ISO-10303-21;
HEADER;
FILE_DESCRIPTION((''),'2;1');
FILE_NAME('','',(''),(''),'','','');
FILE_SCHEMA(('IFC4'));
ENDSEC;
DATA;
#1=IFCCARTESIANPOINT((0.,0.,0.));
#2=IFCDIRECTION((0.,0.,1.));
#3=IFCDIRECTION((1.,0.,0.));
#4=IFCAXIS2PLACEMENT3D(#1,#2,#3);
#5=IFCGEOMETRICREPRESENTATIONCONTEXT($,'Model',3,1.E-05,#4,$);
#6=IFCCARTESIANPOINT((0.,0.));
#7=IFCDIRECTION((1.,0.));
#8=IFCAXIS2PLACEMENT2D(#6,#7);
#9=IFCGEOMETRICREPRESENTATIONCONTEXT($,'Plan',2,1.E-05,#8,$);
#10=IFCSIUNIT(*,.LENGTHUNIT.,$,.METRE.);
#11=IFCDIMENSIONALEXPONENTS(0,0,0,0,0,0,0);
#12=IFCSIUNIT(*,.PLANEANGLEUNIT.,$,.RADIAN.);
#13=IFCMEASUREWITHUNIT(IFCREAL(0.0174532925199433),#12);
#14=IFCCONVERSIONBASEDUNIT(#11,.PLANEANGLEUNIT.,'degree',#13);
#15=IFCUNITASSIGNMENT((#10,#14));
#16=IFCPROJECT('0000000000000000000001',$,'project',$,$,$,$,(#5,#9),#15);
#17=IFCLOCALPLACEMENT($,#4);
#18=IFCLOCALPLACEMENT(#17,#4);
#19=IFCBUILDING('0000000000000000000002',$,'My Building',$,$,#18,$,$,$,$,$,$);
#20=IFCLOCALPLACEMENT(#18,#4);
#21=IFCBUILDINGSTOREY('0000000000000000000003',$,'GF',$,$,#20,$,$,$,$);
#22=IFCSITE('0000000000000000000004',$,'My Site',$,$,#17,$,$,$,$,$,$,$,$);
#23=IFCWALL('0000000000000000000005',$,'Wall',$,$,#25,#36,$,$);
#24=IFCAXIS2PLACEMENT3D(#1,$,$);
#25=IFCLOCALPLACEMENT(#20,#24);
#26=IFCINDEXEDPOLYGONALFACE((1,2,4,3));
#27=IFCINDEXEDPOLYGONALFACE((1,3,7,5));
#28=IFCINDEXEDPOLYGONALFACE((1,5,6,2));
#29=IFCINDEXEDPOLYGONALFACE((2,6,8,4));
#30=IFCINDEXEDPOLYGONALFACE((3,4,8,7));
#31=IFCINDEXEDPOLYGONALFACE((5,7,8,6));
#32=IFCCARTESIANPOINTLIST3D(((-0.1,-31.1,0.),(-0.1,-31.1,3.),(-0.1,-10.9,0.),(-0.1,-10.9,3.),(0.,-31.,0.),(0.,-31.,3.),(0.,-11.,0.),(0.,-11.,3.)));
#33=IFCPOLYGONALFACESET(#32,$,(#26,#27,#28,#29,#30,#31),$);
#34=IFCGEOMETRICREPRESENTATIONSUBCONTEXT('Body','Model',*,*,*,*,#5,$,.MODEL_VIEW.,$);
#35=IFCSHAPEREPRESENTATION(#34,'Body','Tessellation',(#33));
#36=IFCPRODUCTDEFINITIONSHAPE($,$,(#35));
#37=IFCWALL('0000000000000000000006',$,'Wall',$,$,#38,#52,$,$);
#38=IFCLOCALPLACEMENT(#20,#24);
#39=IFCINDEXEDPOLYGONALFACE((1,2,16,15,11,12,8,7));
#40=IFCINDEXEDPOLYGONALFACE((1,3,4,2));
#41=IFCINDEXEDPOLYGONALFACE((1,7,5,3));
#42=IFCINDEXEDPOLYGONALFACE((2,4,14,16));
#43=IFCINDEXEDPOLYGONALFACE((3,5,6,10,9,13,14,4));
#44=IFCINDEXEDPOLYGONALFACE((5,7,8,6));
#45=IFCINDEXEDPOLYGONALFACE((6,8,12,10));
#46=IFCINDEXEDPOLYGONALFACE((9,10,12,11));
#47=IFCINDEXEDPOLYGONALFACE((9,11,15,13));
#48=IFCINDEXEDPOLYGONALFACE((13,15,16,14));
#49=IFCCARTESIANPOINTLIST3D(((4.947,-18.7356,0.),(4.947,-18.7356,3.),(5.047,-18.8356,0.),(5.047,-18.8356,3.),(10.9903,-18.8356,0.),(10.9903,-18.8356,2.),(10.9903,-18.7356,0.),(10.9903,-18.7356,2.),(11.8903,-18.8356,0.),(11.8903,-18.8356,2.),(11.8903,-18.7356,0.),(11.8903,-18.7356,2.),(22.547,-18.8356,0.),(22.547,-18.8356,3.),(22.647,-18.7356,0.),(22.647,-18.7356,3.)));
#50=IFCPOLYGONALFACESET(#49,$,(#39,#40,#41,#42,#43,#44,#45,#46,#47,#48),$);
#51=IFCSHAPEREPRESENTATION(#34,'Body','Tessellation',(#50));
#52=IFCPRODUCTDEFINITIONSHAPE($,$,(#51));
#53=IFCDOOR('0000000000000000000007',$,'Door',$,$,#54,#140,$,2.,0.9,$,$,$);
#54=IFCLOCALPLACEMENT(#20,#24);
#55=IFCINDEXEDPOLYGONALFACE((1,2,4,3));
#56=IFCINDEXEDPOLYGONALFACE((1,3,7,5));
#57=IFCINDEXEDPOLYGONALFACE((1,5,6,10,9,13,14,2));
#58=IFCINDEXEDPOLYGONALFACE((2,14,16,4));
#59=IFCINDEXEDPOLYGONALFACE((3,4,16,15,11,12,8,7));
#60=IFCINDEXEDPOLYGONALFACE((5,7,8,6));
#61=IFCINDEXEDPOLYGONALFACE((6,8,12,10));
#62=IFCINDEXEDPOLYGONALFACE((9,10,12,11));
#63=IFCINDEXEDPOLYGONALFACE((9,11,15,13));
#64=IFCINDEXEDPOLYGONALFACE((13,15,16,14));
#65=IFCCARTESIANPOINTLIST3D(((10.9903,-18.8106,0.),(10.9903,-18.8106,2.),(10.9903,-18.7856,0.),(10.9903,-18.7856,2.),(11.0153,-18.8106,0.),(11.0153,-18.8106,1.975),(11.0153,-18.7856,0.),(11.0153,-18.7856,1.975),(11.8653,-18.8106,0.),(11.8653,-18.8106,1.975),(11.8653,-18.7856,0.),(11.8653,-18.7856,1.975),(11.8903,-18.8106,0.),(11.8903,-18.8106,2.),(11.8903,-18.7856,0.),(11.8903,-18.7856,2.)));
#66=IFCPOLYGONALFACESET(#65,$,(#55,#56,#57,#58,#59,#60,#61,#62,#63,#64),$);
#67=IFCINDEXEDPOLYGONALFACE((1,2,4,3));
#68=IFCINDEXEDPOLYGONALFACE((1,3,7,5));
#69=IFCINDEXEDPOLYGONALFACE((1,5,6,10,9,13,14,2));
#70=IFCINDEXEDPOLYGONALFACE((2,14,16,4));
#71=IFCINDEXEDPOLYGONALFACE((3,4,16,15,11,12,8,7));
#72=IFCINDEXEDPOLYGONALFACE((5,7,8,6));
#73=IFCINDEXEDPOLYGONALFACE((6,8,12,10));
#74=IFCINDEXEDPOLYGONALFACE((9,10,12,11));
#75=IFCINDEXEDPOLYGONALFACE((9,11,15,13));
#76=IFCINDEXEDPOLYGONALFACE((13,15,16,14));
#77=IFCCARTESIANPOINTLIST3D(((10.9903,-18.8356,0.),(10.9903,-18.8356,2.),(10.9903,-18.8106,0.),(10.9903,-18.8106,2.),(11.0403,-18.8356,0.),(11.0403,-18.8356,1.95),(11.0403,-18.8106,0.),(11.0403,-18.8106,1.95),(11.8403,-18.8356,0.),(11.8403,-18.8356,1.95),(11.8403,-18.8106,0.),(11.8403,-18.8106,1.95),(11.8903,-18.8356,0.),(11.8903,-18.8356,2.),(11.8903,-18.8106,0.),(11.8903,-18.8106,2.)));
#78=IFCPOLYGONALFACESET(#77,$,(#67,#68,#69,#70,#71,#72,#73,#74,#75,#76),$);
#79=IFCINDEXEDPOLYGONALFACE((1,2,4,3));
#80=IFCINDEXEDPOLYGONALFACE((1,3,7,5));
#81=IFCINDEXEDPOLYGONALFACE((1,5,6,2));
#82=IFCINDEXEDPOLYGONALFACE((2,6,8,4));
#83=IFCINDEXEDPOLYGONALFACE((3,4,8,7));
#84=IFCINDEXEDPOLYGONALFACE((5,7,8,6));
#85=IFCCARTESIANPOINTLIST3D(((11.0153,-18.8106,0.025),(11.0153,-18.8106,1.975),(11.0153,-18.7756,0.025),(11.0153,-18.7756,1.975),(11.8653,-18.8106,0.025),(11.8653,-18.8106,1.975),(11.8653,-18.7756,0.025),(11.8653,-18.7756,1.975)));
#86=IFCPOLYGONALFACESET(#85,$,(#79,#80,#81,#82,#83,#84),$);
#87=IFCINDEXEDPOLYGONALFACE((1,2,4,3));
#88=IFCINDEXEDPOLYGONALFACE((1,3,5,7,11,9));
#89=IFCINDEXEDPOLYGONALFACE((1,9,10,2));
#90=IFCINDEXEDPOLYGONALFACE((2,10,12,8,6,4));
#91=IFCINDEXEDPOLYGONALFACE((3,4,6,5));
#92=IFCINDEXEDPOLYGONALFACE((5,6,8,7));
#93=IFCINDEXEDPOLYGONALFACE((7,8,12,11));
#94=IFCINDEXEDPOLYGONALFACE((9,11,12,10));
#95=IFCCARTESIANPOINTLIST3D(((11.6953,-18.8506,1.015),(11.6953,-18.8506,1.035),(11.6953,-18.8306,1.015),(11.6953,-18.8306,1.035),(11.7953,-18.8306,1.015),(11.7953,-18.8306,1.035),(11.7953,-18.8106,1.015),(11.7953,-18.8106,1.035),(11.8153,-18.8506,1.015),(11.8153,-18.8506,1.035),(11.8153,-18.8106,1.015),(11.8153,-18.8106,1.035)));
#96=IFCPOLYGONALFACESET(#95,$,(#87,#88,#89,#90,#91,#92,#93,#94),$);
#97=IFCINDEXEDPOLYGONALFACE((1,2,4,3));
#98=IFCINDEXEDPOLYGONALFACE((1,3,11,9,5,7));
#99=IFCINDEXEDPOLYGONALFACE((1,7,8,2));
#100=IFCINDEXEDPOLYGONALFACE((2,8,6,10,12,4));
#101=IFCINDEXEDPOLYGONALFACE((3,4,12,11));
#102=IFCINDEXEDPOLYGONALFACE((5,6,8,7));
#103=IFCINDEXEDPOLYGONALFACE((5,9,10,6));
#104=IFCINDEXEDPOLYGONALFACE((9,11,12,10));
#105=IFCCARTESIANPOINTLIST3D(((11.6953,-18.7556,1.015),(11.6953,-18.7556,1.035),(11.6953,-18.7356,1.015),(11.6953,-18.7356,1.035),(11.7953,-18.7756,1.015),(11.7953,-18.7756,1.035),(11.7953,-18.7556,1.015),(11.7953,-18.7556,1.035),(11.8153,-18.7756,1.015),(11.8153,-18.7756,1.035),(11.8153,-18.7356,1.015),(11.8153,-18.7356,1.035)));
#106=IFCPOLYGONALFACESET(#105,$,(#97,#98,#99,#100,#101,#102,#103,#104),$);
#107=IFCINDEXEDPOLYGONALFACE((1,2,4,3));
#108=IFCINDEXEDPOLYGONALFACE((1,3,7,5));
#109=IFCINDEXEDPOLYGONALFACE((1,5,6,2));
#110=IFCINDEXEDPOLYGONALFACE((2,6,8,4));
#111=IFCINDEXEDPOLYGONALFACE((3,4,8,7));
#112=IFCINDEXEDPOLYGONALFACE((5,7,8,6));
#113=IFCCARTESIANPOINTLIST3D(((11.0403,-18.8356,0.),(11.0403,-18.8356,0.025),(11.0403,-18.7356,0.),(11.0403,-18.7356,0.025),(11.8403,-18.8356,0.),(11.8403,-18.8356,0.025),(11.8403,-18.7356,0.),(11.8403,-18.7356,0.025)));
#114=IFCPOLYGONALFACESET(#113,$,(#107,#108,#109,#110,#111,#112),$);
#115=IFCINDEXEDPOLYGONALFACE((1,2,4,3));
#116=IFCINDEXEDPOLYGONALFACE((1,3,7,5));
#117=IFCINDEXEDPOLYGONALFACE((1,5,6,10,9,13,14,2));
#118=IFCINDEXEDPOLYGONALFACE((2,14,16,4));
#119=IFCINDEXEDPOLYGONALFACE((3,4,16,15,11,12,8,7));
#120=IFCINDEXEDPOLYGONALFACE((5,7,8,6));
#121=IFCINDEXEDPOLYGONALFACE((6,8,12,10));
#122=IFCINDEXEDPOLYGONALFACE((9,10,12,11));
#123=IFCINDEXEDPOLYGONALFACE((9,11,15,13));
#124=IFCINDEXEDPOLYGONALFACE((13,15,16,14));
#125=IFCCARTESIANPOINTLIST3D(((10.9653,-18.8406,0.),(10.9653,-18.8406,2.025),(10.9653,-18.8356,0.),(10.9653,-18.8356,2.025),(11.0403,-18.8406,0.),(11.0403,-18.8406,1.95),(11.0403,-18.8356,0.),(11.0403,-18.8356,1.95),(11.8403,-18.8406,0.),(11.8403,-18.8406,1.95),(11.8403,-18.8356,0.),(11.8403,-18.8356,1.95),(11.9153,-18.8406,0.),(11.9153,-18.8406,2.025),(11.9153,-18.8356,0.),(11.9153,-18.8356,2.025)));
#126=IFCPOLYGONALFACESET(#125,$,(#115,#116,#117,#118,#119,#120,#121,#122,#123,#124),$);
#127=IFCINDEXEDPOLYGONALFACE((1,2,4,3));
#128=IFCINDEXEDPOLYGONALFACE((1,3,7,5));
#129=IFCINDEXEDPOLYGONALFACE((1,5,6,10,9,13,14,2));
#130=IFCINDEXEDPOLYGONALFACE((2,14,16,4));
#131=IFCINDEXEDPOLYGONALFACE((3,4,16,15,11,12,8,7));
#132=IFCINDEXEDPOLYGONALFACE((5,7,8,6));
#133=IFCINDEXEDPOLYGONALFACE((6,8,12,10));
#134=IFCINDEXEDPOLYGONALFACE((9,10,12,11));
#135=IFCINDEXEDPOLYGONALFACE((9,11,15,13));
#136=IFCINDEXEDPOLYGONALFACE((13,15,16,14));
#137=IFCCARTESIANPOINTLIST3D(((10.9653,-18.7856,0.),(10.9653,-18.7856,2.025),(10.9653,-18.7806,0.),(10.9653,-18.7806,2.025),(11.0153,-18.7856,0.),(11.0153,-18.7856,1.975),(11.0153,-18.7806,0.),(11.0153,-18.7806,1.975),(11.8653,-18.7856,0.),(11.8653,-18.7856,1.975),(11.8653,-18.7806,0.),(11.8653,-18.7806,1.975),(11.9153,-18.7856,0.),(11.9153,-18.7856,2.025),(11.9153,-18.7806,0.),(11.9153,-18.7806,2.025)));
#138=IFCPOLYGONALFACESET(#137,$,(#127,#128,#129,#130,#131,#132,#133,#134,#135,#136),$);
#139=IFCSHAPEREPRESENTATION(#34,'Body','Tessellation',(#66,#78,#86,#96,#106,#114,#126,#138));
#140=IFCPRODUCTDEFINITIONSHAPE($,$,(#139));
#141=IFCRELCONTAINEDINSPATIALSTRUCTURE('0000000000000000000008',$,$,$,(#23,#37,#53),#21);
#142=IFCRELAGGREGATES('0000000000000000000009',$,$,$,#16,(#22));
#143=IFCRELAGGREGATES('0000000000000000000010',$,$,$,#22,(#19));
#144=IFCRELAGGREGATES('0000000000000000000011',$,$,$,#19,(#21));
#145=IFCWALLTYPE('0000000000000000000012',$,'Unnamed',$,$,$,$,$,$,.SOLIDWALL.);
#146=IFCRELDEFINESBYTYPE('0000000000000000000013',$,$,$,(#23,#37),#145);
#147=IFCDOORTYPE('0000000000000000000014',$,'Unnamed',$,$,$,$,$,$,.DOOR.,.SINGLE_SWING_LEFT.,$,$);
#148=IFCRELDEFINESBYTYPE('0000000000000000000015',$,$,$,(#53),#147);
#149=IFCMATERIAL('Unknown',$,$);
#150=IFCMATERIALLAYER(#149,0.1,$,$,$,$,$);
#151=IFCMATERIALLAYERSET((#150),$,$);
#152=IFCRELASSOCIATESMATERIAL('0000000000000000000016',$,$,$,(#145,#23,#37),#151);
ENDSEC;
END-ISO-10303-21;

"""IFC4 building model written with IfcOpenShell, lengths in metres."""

from ifc_helpers import new_model, entity, si_unit, converted_unit, frame, origin_with_axes, origin_2d_with_axis, place, context, subcontext, project, spatial, line, indexed_curve, outline, extrude, shape, source, transform, mapped, material, layer, layer_set, layer_usage, type_object, type_shapes, element, fill, save


model = new_model("IFC4")

# Units and contexts
model_context = context("Model", 3, precision=1e-05, world=origin_with_axes())
plan_context = context("Plan", 2, precision=1e-05, world=origin_2d_with_axis())
body_context_1 = subcontext(model_context, "Body", "Model", "MODEL_VIEW")
body_context_2 = subcontext(plan_context, "Body", "Plan", "PLAN_VIEW")
ifc_project = project(units=[si_unit("LENGTHUNIT", "METRE"), converted_unit("PLANEANGLEUNIT", "degree", entity("IfcReal", 0.0174532925199433), si_unit("PLANEANGLEUNIT", "RADIAN"), dimensions=[0, 0, 0, 0, 0, 0, 0])], contexts=[model_context, plan_context])

# Site, building, storey
site_placement = place(None, origin_with_axes())
site = spatial("IfcSite", under=ifc_project, at=site_placement, Name="My Site")
building_placement = place(site_placement, origin_with_axes())
building = spatial("IfcBuilding", under=site, at=building_placement, Name="My Building")
storey_placement = place(building_placement, origin_with_axes())
storey = spatial("IfcBuildingStorey", under=building, at=storey_placement, Name="GF")

# Wall
ifc_material = material(Name="Unknown")
ifc_layer = layer(ifc_material, 0.1)
ifc_layer_set = layer_set([ifc_layer])
ifc_layer_usage_1 = layer_usage(ifc_layer_set, "AXIS2", "POSITIVE", 0.0)
wall_type = type_object("IfcWallType", Name="Unnamed", PredefinedType="SOLIDWALL", material=ifc_layer_set)
wall_1_placement = place(storey_placement, frame((0.0, -31.0, 0.0), z_axis=(0.0, 0.0, 1.0), x_axis=(0.0, 1.0, 0.0)))
element("IfcWall", 1, at=wall_1_placement, inside=storey, type_object=wall_type, material=ifc_layer_usage_1, Name="Wall", context=body_context_1, shape_type="SweptSolid", body=[
    extrude(outline(indexed_curve([(0.0, 0.0), (-0.1, 0.1), (20.1, 0.1), (20.0, 0.0)], segments=[line(1, 2, 3, 4, 1)])), origin_with_axes(), (0.0, 0.0, 1.0), 3.0),
])

# Shared definitions
shared_shape_1 = source(origin_with_axes(), body_context_1, "Body", "SweptSolid", [
    extrude(outline(indexed_curve([(0.0, 0.0), (0.9, 0.0), (0.9, 2.0), (0.0, 2.0)], segments=[line(1, 2, 3, 4, 1)])), frame((0.0, -0.6, 0.0), z_axis=(0.0, -1.0, 0.0), x_axis=(1.0, 0.0, 0.0)), (0.0, 0.0, -1.0), 1.2),
])
door_type = type_object("IfcDoorType", Name="Unnamed", OperationType="SINGLE_SWING_LEFT", PredefinedType="DOOR")
shared_shape_2 = source(origin_with_axes(), body_context_1, "Body", "SweptSolid", [
    extrude(outline(indexed_curve([(0.0, 0.0), (0.0, 2.0), (0.9, 2.0), (0.9, 0.0), (0.875, 0.0), (0.875, 1.975), (0.025, 1.975), (0.025, 0.0)], segments=[line(1, 2, 3, 4, 5, 6, 7, 8, 1)])), frame((0.0, 0.025, 0.0), z_axis=(0.0, -1.0, 0.0), x_axis=(1.0, 0.0, 0.0)), (0.0, 0.0, -1.0), 0.025),
    extrude(outline(indexed_curve([(0.0, 0.0), (0.0, 2.0), (0.9, 2.0), (0.9, 0.0), (0.85, 0.0), (0.85, 1.95), (0.05, 1.95), (0.05, 0.0)], segments=[line(1, 2, 3, 4, 5, 6, 7, 8, 1)])), frame((0.0, 0.0, 0.0), z_axis=(0.0, -1.0, 0.0), x_axis=(1.0, 0.0, 0.0)), (0.0, 0.0, -1.0), 0.025),
    extrude(outline(indexed_curve([(0.0, 0.0), (0.85, 0.0), (0.85, 0.035), (0.0, 0.035)], segments=[line(1, 2, 3, 4, 1)])), frame((0.025, 0.025, 0.025), z_axis=(0.0, 0.0, 1.0), x_axis=(1.0, 0.0, 0.0)), (0.0, 0.0, 1.0), 1.95),
    extrude(outline(indexed_curve([(0.0, 0.0), (0.0, -0.04), (-0.12, -0.04), (-0.12, -0.02), (-0.02, -0.02), (-0.02, 0.0)], segments=[line(1, 2, 3, 4, 5, 6, 1)])), frame((0.825, 0.025, 1.015), z_axis=(0.0, 0.0, 1.0), x_axis=(1.0, 0.0, 0.0)), (0.0, 0.0, 1.0), 0.02),
    extrude(outline(indexed_curve([(0.0, 0.0), (0.0, 0.04), (-0.12, 0.04), (-0.12, 0.02), (-0.02, 0.02), (-0.02, 0.0)], segments=[line(1, 2, 3, 4, 5, 6, 1)])), frame((0.825, 0.06, 1.015), z_axis=(0.0, 0.0, 1.0), x_axis=(1.0, 0.0, 0.0)), (0.0, 0.0, 1.0), 0.02),
    extrude(outline(indexed_curve([(0.0, 0.0), (0.8, 0.0), (0.8, 0.1), (0.0, 0.1)], segments=[line(1, 2, 3, 4, 1)])), frame((0.05, 0.0, 0.0), z_axis=(0.0, 0.0, 1.0), x_axis=(1.0, 0.0, 0.0)), (0.0, 0.0, 1.0), 0.025),
    extrude(outline(indexed_curve([(0.0, 0.0), (0.0, 2.025), (0.95, 2.025), (0.95, 0.0), (0.875, 0.0), (0.875, 1.95), (0.075, 1.95), (0.075, 0.0)], segments=[line(1, 2, 3, 4, 5, 6, 7, 8, 1)])), frame((-0.025, -0.005, 0.0), z_axis=(0.0, -1.0, 0.0), x_axis=(1.0, 0.0, 0.0)), (0.0, 0.0, -1.0), 0.005),
    extrude(outline(indexed_curve([(0.0, 0.0), (0.0, 2.025), (0.95, 2.025), (0.95, 0.0), (0.9, 0.0), (0.9, 1.975), (0.05, 1.975), (0.05, 0.0)], segments=[line(1, 2, 3, 4, 5, 6, 7, 8, 1)])), frame((-0.025, 0.05, 0.0), z_axis=(0.0, -1.0, 0.0), x_axis=(1.0, 0.0, 0.0)), (0.0, 0.0, -1.0), 0.005),
])
shared_shape_3 = source(origin_with_axes(), body_context_2, "Body", "Curve2D", [
    entity("IfcIndexedPolyCurve", entity("IfcCartesianPointList2D", [[0.0, 0.0], [0.0, 0.05], [0.025, 0.05], [0.025, 0.025], [0.05, 0.025], [0.05, 0.0]]), [entity("IfcLineIndex", [1, 2, 3, 4, 5, 6, 1])]),
    entity("IfcIndexedPolyCurve", entity("IfcCartesianPointList2D", [[0.9, 0.0], [0.9, 0.05], [0.875, 0.05], [0.875, 0.025], [0.85, 0.025], [0.85, 0.0]]), [entity("IfcLineIndex", [1, 2, 3, 4, 5, 6, 1])]),
    entity("IfcTrimmedCurve", entity("IfcEllipse", entity("IfcAxis2Placement2D", entity("IfcCartesianPoint", [0.06, 0.05]), entity("IfcDirection", [1.0, 0.0])), 0.815, 0.85), [entity("IfcCartesianPoint", [0.875, 0.05])], [entity("IfcCartesianPoint", [0.06, 0.9])], True, "CARTESIAN"),
    entity("IfcIndexedPolyCurve", entity("IfcCartesianPointList2D", [[0.025, 0.05], [0.06, 0.05], [0.06, 0.9], [0.025, 0.9]]), [entity("IfcLineIndex", [1, 2, 3, 4, 1])]),
])
type_shapes(door_type, [shared_shape_2, shared_shape_3])

# Wall, opening, door
ifc_layer_usage_2 = layer_usage(ifc_layer_set, "AXIS2", "POSITIVE", 0.0)
wall_2_placement = place(storey_placement, frame((5.047, -18.8356, 0.0), z_axis=(0.0, 0.0, 1.0), x_axis=(1.0, 0.0, 0.0)))
wall_2 = element("IfcWall", 2, at=wall_2_placement, inside=storey, type_object=wall_type, material=ifc_layer_usage_2, Name="Wall", context=body_context_1, shape_type="SweptSolid", body=[
    extrude(outline(indexed_curve([(0.0, 0.0), (-0.1, 0.1), (17.6, 0.1), (17.5, 0.0)], segments=[line(1, 2, 3, 4, 1)])), origin_with_axes(), (0.0, 0.0, 1.0), 3.0),
])
opening_1_placement = place(wall_2_placement, frame((5.9433, 0.0, 0.0), z_axis=(0.0, 0.0, 1.0), x_axis=(1.0, 0.0, 0.0)))
opening_1 = element("IfcOpeningElement", 3, at=opening_1_placement, cuts=wall_2, PredefinedType="OPENING", context=body_context_1, shape_type="MappedRepresentation", body=[
    mapped(shared_shape_1, transform((0.0, 0.0, 0.0), x_axis=(1.0, 0.0, 0.0), y_axis=(0.0, 1.0, 0.0), z_axis=(0.0, 0.0, 1.0), scale=1.0)),
])
door_1_placement = place(opening_1_placement, origin_with_axes())
door_1 = element("IfcDoor", 4, at=door_1_placement, inside=storey, type_object=door_type, Name="Door", OverallHeight=2.0, OverallWidth=0.9, shapes=[
    shape(body_context_1, "Body", "MappedRepresentation", [mapped(shared_shape_2, transform((0.0, 0.0, 0.0), x_axis=(1.0, 0.0, 0.0), y_axis=(0.0, 1.0, 0.0), z_axis=(0.0, 0.0, 1.0), scale=1.0))]),
    shape(body_context_2, "Body", "MappedRepresentation", [mapped(shared_shape_3, transform((0.0, 0.0, 0.0), x_axis=(1.0, 0.0, 0.0), y_axis=(0.0, 1.0, 0.0), z_axis=(0.0, 0.0, 1.0), scale=1.0))]),
])
fill(opening_1, door_1)

save(model, "model.ifc")
